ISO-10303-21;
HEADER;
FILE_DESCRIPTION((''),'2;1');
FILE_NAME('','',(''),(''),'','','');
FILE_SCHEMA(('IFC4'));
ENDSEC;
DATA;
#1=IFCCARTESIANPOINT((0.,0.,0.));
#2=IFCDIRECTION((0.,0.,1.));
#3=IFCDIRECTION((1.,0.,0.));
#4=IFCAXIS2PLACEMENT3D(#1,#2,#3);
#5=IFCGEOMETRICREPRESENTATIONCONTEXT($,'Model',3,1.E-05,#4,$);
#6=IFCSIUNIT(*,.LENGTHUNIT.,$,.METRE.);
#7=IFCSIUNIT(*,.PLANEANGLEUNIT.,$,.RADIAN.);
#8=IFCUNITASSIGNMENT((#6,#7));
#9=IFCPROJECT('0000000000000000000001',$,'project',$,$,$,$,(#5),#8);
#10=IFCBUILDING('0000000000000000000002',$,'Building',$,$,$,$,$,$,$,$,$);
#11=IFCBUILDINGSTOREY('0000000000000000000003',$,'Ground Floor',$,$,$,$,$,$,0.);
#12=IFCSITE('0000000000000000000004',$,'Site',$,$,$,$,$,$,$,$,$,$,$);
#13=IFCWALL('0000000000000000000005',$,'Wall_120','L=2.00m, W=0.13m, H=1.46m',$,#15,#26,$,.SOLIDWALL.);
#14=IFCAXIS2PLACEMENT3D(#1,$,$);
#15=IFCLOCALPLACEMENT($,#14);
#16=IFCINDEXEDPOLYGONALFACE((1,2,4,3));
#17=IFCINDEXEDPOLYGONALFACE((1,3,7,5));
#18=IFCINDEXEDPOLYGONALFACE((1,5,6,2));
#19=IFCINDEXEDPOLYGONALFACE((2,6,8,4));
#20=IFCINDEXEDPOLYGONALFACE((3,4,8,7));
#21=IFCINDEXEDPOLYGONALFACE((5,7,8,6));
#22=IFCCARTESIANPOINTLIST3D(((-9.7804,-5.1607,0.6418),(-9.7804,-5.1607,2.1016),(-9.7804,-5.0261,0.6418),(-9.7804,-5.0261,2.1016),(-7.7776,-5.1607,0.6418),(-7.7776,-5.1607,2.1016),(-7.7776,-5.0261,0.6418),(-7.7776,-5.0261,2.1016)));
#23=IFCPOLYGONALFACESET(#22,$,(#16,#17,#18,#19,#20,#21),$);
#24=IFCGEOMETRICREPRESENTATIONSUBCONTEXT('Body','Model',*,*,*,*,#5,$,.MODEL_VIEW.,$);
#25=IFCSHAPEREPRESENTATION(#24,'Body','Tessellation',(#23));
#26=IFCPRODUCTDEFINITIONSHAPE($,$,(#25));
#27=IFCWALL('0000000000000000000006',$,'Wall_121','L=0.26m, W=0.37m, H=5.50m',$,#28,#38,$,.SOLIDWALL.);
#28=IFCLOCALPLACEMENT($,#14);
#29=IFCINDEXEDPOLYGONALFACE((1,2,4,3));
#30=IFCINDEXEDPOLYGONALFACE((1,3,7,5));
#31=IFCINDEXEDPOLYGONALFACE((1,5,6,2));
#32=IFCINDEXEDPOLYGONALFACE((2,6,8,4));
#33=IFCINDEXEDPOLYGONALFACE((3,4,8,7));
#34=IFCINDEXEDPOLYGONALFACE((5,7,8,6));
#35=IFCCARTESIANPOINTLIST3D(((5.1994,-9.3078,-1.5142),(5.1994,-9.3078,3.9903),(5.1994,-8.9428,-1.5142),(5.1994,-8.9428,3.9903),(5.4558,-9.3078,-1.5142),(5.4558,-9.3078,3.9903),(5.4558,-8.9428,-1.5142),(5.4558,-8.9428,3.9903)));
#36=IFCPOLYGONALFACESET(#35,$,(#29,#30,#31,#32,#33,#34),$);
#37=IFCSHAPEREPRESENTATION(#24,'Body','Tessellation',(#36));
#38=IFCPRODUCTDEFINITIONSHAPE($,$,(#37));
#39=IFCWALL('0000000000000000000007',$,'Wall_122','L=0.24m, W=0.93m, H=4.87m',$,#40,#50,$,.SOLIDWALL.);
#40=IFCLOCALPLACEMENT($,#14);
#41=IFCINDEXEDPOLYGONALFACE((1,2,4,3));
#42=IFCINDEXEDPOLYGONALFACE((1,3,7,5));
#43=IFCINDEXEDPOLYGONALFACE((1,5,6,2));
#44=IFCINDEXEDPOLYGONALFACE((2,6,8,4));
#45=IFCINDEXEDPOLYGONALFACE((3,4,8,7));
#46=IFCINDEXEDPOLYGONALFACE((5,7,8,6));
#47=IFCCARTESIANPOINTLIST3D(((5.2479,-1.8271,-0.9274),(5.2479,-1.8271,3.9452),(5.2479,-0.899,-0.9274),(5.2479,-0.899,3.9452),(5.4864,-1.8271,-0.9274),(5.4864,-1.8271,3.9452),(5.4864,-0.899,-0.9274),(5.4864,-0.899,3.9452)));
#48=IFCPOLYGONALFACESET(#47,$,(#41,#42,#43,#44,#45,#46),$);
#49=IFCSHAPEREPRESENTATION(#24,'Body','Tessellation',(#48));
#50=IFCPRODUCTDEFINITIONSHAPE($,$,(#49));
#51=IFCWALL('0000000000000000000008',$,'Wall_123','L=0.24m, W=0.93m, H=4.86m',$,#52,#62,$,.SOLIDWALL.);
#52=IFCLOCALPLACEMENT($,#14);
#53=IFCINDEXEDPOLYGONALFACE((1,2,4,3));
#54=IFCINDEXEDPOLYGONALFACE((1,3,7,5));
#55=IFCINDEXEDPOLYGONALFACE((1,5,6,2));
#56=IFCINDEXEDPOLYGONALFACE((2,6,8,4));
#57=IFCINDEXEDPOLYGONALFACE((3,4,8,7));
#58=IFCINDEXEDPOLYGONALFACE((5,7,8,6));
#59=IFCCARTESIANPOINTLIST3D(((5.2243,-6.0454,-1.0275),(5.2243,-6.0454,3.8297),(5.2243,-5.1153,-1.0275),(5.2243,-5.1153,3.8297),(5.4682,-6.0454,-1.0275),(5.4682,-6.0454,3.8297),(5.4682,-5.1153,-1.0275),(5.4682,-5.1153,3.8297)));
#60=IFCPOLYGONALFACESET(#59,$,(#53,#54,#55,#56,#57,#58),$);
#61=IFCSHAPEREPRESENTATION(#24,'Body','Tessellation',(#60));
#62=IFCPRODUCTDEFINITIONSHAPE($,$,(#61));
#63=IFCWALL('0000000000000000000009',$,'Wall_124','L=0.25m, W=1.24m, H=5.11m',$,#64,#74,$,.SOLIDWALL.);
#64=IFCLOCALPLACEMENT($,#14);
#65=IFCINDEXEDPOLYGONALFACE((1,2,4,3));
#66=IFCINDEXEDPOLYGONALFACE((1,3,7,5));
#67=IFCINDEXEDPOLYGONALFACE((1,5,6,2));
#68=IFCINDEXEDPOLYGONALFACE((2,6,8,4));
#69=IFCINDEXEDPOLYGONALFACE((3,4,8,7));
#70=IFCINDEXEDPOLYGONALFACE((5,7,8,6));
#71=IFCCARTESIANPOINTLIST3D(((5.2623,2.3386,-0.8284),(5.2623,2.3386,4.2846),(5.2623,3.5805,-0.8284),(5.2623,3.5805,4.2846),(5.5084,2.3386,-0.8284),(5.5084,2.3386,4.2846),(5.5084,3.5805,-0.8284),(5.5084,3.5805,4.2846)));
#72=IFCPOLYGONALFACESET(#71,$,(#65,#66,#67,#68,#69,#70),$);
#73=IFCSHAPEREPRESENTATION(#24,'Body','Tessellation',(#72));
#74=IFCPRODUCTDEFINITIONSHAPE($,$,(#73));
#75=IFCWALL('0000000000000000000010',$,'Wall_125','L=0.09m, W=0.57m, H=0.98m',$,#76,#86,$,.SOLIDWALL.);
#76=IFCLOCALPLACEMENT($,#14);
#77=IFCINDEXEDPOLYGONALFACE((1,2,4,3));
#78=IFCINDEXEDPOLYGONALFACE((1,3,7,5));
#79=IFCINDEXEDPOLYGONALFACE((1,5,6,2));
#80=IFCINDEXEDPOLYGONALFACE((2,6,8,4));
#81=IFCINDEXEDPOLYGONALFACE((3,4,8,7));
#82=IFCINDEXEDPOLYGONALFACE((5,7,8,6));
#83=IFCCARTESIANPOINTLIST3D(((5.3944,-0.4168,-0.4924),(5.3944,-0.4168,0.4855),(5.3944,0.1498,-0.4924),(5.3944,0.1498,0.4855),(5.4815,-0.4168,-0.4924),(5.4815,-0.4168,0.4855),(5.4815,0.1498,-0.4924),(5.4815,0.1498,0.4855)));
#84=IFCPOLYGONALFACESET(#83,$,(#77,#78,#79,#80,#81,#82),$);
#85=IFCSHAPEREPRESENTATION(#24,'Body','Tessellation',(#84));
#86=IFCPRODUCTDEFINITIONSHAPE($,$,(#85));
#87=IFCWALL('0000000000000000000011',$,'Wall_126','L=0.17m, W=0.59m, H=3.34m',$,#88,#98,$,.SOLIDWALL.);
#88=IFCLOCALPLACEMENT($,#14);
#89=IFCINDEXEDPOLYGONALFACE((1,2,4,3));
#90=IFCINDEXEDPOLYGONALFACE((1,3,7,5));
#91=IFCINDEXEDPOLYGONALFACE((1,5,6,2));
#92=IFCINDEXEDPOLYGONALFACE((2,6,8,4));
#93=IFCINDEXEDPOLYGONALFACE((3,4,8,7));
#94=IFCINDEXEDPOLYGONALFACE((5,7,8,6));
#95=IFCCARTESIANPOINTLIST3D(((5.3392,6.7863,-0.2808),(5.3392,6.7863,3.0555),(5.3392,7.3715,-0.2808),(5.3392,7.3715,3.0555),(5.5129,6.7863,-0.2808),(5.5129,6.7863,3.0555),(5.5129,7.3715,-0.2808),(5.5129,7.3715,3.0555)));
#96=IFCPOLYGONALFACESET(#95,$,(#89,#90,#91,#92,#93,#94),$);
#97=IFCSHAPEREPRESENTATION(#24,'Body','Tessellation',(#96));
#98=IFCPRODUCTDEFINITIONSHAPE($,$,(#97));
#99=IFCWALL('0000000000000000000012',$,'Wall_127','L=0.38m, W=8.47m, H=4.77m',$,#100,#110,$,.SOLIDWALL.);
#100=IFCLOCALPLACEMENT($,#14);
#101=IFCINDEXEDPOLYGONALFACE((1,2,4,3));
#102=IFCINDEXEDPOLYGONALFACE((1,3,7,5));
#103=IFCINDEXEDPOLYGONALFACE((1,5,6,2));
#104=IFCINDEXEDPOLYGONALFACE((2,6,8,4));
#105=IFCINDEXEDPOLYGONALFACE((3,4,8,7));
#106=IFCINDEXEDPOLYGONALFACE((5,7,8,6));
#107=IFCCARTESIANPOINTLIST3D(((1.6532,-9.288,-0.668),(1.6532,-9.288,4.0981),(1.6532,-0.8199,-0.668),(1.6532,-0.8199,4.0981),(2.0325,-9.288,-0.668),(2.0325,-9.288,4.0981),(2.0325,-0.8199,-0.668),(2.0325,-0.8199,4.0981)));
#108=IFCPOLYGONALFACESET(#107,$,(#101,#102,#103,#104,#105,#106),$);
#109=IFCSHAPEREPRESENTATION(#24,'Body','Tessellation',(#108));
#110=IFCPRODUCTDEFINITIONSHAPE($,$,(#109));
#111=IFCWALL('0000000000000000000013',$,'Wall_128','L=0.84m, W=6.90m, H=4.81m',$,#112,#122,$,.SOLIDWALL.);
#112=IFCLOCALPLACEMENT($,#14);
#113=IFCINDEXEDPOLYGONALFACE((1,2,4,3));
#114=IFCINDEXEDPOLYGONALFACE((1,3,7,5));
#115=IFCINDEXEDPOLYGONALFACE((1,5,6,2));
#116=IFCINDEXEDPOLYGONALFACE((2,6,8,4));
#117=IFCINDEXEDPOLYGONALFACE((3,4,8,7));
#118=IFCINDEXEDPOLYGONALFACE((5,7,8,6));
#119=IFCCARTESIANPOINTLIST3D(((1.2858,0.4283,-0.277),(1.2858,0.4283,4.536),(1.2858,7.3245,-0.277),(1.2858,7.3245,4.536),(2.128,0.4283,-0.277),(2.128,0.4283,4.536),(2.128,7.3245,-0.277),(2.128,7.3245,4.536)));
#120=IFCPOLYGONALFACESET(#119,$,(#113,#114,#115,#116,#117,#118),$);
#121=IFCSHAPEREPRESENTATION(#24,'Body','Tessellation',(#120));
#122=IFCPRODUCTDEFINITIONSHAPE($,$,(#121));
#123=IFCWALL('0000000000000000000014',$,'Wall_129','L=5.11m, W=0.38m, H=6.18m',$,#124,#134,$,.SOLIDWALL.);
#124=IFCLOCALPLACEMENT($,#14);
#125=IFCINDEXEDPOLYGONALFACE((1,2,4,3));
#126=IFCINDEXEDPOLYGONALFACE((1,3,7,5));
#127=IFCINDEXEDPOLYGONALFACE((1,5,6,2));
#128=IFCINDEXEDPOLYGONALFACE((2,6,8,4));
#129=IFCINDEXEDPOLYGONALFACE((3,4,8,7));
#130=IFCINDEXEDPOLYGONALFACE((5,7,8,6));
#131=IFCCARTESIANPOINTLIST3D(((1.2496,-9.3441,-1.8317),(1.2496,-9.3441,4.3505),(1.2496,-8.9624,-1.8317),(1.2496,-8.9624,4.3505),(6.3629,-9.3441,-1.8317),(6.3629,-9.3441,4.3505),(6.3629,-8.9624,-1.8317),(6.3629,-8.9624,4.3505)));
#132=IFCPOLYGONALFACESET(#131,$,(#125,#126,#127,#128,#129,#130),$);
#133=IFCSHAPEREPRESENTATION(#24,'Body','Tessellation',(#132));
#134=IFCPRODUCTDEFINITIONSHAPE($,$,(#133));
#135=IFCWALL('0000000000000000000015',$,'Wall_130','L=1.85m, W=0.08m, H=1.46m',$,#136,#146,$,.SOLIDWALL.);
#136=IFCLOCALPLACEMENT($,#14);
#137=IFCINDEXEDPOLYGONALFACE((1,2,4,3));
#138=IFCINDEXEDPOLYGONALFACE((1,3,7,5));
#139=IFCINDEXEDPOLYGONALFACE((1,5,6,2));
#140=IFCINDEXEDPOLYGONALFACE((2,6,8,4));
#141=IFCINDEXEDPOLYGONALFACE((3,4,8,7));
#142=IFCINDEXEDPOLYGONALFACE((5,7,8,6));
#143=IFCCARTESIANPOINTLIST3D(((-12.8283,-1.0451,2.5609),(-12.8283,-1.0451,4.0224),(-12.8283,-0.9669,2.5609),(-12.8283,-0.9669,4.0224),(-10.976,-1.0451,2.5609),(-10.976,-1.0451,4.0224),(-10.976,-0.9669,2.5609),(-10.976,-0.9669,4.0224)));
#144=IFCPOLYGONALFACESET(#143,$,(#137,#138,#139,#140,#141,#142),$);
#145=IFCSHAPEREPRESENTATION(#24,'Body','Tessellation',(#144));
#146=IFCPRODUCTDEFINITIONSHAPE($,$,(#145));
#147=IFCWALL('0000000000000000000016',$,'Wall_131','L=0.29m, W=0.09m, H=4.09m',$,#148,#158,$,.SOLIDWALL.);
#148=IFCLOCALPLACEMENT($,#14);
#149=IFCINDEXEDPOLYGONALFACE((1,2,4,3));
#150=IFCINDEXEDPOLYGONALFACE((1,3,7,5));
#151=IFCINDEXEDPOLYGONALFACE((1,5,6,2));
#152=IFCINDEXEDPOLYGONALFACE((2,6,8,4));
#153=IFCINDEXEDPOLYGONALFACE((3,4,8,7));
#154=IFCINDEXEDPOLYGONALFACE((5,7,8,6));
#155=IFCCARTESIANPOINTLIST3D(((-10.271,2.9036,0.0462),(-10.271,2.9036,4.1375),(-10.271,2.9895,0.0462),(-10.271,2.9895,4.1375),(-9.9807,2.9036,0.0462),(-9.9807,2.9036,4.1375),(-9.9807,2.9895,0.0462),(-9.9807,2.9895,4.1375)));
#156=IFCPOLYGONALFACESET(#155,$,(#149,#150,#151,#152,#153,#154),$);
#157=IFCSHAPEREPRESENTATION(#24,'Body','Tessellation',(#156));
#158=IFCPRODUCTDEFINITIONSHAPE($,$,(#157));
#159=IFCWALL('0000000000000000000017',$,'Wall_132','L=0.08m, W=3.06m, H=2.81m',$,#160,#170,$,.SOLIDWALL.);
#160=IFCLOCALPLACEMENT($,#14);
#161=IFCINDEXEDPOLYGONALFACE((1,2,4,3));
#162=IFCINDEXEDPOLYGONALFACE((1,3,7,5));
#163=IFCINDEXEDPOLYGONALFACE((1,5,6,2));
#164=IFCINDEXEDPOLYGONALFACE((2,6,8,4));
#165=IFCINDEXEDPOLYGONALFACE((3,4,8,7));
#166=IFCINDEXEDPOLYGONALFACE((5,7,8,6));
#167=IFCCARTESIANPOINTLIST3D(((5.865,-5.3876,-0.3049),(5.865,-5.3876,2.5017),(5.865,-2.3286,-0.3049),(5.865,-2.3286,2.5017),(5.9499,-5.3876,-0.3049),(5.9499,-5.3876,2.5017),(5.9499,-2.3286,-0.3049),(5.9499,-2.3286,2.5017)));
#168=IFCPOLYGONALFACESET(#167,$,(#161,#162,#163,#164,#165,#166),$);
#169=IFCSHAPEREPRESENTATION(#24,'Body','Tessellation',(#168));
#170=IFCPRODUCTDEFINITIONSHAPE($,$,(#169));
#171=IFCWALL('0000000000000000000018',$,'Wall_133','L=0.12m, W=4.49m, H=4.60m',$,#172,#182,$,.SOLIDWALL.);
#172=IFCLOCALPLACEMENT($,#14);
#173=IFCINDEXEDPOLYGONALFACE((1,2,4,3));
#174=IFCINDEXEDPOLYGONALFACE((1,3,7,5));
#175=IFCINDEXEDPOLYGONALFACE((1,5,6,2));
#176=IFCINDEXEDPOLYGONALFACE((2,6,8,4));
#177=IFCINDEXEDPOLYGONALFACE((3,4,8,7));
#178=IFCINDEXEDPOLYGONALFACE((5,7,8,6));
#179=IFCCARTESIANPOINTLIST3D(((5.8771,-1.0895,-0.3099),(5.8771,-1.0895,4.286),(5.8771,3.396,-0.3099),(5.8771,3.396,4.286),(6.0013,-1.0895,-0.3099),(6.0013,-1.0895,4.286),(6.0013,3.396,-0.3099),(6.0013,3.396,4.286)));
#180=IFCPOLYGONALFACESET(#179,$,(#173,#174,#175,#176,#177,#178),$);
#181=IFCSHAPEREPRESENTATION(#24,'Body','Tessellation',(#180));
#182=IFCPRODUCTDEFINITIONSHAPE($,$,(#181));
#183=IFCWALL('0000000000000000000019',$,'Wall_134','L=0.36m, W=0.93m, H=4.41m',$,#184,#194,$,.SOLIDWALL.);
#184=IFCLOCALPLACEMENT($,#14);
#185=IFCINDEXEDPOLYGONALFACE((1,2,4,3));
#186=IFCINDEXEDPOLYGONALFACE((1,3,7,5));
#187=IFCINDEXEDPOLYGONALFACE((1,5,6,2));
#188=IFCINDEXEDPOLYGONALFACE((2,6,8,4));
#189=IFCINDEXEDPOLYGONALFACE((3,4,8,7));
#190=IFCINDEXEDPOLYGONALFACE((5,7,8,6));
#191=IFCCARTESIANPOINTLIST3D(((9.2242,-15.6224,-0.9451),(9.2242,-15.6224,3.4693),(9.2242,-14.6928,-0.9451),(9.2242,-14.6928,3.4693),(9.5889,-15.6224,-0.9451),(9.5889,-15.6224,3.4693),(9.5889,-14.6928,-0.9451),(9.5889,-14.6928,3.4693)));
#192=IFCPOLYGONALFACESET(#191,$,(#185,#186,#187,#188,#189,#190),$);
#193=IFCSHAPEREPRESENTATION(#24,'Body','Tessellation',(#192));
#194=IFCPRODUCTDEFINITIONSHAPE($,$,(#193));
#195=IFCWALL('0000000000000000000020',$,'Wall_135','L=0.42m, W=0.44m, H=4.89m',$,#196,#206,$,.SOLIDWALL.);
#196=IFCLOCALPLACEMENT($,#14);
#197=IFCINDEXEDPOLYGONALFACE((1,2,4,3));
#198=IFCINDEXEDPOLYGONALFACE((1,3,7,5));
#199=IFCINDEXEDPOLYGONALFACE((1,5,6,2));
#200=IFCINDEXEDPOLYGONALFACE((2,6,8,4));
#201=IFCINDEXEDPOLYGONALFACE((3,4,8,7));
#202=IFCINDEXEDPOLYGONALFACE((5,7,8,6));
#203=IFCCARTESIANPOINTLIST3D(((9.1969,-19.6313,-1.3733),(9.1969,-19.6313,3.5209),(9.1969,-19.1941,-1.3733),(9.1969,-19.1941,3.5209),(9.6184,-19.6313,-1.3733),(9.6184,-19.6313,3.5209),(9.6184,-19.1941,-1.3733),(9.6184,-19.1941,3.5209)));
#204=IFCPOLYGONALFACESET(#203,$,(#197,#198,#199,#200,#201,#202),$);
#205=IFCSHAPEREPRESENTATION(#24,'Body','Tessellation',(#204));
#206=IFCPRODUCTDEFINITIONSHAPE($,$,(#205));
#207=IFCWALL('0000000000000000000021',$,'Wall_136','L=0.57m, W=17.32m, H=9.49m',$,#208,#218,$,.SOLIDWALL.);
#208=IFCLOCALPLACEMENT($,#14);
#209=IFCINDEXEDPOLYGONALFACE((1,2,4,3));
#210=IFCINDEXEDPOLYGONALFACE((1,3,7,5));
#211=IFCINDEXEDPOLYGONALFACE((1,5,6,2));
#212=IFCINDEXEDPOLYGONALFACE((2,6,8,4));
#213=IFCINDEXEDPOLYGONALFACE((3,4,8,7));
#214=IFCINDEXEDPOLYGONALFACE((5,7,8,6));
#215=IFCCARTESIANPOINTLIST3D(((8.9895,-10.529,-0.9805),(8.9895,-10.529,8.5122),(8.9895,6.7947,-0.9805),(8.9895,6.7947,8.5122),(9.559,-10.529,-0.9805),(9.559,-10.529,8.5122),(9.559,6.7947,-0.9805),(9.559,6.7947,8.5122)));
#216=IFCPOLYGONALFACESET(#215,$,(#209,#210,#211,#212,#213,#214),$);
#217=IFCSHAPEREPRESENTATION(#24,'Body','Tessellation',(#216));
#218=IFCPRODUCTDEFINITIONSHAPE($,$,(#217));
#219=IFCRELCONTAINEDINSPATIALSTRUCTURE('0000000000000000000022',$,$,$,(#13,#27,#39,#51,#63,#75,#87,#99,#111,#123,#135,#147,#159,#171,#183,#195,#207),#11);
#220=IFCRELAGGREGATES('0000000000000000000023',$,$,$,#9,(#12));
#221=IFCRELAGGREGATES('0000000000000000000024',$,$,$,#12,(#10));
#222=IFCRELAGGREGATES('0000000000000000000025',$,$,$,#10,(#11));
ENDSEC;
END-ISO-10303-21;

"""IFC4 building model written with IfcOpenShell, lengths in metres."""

from ifc_helpers import new_model, si_unit, frame, origin_with_axes, origin_2d, context, subcontext, project, spatial, rectangle, extrude, element, save


model = new_model("IFC4")

# Units and contexts
model_context = context("Model", 3, precision=1e-05, world=origin_with_axes())
body_context = subcontext(model_context, "Body", "Model", "MODEL_VIEW")
ifc_project = project(units=[si_unit("LENGTHUNIT", "METRE"), si_unit("PLANEANGLEUNIT", "RADIAN")], contexts=[model_context])

# Site, building, storey
site = spatial("IfcSite", under=ifc_project, Name="Site")
building = spatial("IfcBuilding", under=site, Name="Building")
storey = spatial("IfcBuildingStorey", under=building, Name="Ground Floor", Elevation=0.0)

# Walls
element("IfcWall", 1, inside=storey, Name="Wall_120", Description="L=2.00m, W=0.13m, H=1.46m", PredefinedType="SOLIDWALL", context=body_context, shape_type="SweptSolid", body=[
    extrude(rectangle(XDim=2.0028, YDim=0.1346, at=origin_2d()), frame((-8.779, -5.0934, 0.6418), z_axis=(0.0, 0.0, 1.0), x_axis=(1.0, 0.0, 0.0)), (0.0, 0.0, 1.0), 1.4598),
])
element("IfcWall", 2, inside=storey, Name="Wall_121", Description="L=0.26m, W=0.37m, H=5.50m", PredefinedType="SOLIDWALL", context=body_context, shape_type="SweptSolid", body=[
    extrude(rectangle(XDim=0.2563, YDim=0.365, at=origin_2d()), frame((5.3276, -9.1253, -1.5142), z_axis=(0.0, 0.0, 1.0), x_axis=(1.0, 0.0, 0.0)), (0.0, 0.0, 1.0), 5.5045),
])
element("IfcWall", 3, inside=storey, Name="Wall_122", Description="L=0.24m, W=0.93m, H=4.87m", PredefinedType="SOLIDWALL", context=body_context, shape_type="SweptSolid", body=[
    extrude(rectangle(XDim=0.2385, YDim=0.9281, at=origin_2d()), frame((5.3671, -1.3631, -0.9274), z_axis=(0.0, 0.0, 1.0), x_axis=(1.0, 0.0, 0.0)), (0.0, 0.0, 1.0), 4.8725),
])
element("IfcWall", 4, inside=storey, Name="Wall_123", Description="L=0.24m, W=0.93m, H=4.86m", PredefinedType="SOLIDWALL", context=body_context, shape_type="SweptSolid", body=[
    extrude(rectangle(XDim=0.2439, YDim=0.9301, at=origin_2d()), frame((5.3463, -5.5804, -1.0275), z_axis=(0.0, 0.0, 1.0), x_axis=(1.0, 0.0, 0.0)), (0.0, 0.0, 1.0), 4.8572),
])
element("IfcWall", 5, inside=storey, Name="Wall_124", Description="L=0.25m, W=1.24m, H=5.11m", PredefinedType="SOLIDWALL", context=body_context, shape_type="SweptSolid", body=[
    extrude(rectangle(XDim=0.2461, YDim=1.2418, at=origin_2d()), frame((5.3853, 2.9595, -0.8284), z_axis=(0.0, 0.0, 1.0), x_axis=(1.0, 0.0, 0.0)), (0.0, 0.0, 1.0), 5.113),
])
element("IfcWall", 6, inside=storey, Name="Wall_125", Description="L=0.09m, W=0.57m, H=0.98m", PredefinedType="SOLIDWALL", context=body_context, shape_type="SweptSolid", body=[
    extrude(rectangle(XDim=0.0871, YDim=0.5666, at=origin_2d()), frame((5.438, -0.1335, -0.4924), z_axis=(0.0, 0.0, 1.0), x_axis=(1.0, 0.0, 0.0)), (0.0, 0.0, 1.0), 0.9779),
])
element("IfcWall", 7, inside=storey, Name="Wall_126", Description="L=0.17m, W=0.59m, H=3.34m", PredefinedType="SOLIDWALL", context=body_context, shape_type="SweptSolid", body=[
    extrude(rectangle(XDim=0.1738, YDim=0.5852, at=origin_2d()), frame((5.4261, 7.0789, -0.2808), z_axis=(0.0, 0.0, 1.0), x_axis=(1.0, 0.0, 0.0)), (0.0, 0.0, 1.0), 3.3363),
])
element("IfcWall", 8, inside=storey, Name="Wall_127", Description="L=0.38m, W=8.47m, H=4.77m", PredefinedType="SOLIDWALL", context=body_context, shape_type="SweptSolid", body=[
    extrude(rectangle(XDim=0.3793, YDim=8.4681, at=origin_2d()), frame((1.8429, -5.054, -0.668), z_axis=(0.0, 0.0, 1.0), x_axis=(1.0, 0.0, 0.0)), (0.0, 0.0, 1.0), 4.7661),
])
element("IfcWall", 9, inside=storey, Name="Wall_128", Description="L=0.84m, W=6.90m, H=4.81m", PredefinedType="SOLIDWALL", context=body_context, shape_type="SweptSolid", body=[
    extrude(rectangle(XDim=0.8422, YDim=6.8962, at=origin_2d()), frame((1.7069, 3.8764, -0.277), z_axis=(0.0, 0.0, 1.0), x_axis=(1.0, 0.0, 0.0)), (0.0, 0.0, 1.0), 4.8129),
])
element("IfcWall", 10, inside=storey, Name="Wall_129", Description="L=5.11m, W=0.38m, H=6.18m", PredefinedType="SOLIDWALL", context=body_context, shape_type="SweptSolid", body=[
    extrude(rectangle(XDim=5.1133, YDim=0.3817, at=origin_2d()), frame((3.8063, -9.1532, -1.8317), z_axis=(0.0, 0.0, 1.0), x_axis=(1.0, 0.0, 0.0)), (0.0, 0.0, 1.0), 6.1822),
])
element("IfcWall", 11, inside=storey, Name="Wall_130", Description="L=1.85m, W=0.08m, H=1.46m", PredefinedType="SOLIDWALL", context=body_context, shape_type="SweptSolid", body=[
    extrude(rectangle(XDim=1.8523, YDim=0.0783, at=origin_2d()), frame((-11.9021, -1.006, 2.5609), z_axis=(0.0, 0.0, 1.0), x_axis=(1.0, 0.0, 0.0)), (0.0, 0.0, 1.0), 1.4615),
])
element("IfcWall", 12, inside=storey, Name="Wall_131", Description="L=0.29m, W=0.09m, H=4.09m", PredefinedType="SOLIDWALL", context=body_context, shape_type="SweptSolid", body=[
    extrude(rectangle(XDim=0.2903, YDim=0.0859, at=origin_2d()), frame((-10.1258, 2.9466, 0.0462), z_axis=(0.0, 0.0, 1.0), x_axis=(1.0, 0.0, 0.0)), (0.0, 0.0, 1.0), 4.0912),
])
element("IfcWall", 13, inside=storey, Name="Wall_132", Description="L=0.08m, W=3.06m, H=2.81m", PredefinedType="SOLIDWALL", context=body_context, shape_type="SweptSolid", body=[
    extrude(rectangle(XDim=0.0849, YDim=3.059, at=origin_2d()), frame((5.9074, -3.8581, -0.3049), z_axis=(0.0, 0.0, 1.0), x_axis=(1.0, 0.0, 0.0)), (0.0, 0.0, 1.0), 2.8066),
])
element("IfcWall", 14, inside=storey, Name="Wall_133", Description="L=0.12m, W=4.49m, H=4.60m", PredefinedType="SOLIDWALL", context=body_context, shape_type="SweptSolid", body=[
    extrude(rectangle(XDim=0.1242, YDim=4.4854, at=origin_2d()), frame((5.9392, 1.1533, -0.3099), z_axis=(0.0, 0.0, 1.0), x_axis=(1.0, 0.0, 0.0)), (0.0, 0.0, 1.0), 4.5959),
])
element("IfcWall", 15, inside=storey, Name="Wall_134", Description="L=0.36m, W=0.93m, H=4.41m", PredefinedType="SOLIDWALL", context=body_context, shape_type="SweptSolid", body=[
    extrude(rectangle(XDim=0.3647, YDim=0.9296, at=origin_2d()), frame((9.4065, -15.1576, -0.9451), z_axis=(0.0, 0.0, 1.0), x_axis=(1.0, 0.0, 0.0)), (0.0, 0.0, 1.0), 4.4145),
])
element("IfcWall", 16, inside=storey, Name="Wall_135", Description="L=0.42m, W=0.44m, H=4.89m", PredefinedType="SOLIDWALL", context=body_context, shape_type="SweptSolid", body=[
    extrude(rectangle(XDim=0.4215, YDim=0.4372, at=origin_2d()), frame((9.4076, -19.4127, -1.3733), z_axis=(0.0, 0.0, 1.0), x_axis=(1.0, 0.0, 0.0)), (0.0, 0.0, 1.0), 4.8942),
])
element("IfcWall", 17, inside=storey, Name="Wall_136", Description="L=0.57m, W=17.32m, H=9.49m", PredefinedType="SOLIDWALL", context=body_context, shape_type="SweptSolid", body=[
    extrude(rectangle(XDim=0.5695, YDim=17.3237, at=origin_2d()), frame((9.2742, -1.8671, -0.9805), z_axis=(0.0, 0.0, 1.0), x_axis=(1.0, 0.0, 0.0)), (0.0, 0.0, 1.0), 9.4927),
])

save(model, "model.ifc")
